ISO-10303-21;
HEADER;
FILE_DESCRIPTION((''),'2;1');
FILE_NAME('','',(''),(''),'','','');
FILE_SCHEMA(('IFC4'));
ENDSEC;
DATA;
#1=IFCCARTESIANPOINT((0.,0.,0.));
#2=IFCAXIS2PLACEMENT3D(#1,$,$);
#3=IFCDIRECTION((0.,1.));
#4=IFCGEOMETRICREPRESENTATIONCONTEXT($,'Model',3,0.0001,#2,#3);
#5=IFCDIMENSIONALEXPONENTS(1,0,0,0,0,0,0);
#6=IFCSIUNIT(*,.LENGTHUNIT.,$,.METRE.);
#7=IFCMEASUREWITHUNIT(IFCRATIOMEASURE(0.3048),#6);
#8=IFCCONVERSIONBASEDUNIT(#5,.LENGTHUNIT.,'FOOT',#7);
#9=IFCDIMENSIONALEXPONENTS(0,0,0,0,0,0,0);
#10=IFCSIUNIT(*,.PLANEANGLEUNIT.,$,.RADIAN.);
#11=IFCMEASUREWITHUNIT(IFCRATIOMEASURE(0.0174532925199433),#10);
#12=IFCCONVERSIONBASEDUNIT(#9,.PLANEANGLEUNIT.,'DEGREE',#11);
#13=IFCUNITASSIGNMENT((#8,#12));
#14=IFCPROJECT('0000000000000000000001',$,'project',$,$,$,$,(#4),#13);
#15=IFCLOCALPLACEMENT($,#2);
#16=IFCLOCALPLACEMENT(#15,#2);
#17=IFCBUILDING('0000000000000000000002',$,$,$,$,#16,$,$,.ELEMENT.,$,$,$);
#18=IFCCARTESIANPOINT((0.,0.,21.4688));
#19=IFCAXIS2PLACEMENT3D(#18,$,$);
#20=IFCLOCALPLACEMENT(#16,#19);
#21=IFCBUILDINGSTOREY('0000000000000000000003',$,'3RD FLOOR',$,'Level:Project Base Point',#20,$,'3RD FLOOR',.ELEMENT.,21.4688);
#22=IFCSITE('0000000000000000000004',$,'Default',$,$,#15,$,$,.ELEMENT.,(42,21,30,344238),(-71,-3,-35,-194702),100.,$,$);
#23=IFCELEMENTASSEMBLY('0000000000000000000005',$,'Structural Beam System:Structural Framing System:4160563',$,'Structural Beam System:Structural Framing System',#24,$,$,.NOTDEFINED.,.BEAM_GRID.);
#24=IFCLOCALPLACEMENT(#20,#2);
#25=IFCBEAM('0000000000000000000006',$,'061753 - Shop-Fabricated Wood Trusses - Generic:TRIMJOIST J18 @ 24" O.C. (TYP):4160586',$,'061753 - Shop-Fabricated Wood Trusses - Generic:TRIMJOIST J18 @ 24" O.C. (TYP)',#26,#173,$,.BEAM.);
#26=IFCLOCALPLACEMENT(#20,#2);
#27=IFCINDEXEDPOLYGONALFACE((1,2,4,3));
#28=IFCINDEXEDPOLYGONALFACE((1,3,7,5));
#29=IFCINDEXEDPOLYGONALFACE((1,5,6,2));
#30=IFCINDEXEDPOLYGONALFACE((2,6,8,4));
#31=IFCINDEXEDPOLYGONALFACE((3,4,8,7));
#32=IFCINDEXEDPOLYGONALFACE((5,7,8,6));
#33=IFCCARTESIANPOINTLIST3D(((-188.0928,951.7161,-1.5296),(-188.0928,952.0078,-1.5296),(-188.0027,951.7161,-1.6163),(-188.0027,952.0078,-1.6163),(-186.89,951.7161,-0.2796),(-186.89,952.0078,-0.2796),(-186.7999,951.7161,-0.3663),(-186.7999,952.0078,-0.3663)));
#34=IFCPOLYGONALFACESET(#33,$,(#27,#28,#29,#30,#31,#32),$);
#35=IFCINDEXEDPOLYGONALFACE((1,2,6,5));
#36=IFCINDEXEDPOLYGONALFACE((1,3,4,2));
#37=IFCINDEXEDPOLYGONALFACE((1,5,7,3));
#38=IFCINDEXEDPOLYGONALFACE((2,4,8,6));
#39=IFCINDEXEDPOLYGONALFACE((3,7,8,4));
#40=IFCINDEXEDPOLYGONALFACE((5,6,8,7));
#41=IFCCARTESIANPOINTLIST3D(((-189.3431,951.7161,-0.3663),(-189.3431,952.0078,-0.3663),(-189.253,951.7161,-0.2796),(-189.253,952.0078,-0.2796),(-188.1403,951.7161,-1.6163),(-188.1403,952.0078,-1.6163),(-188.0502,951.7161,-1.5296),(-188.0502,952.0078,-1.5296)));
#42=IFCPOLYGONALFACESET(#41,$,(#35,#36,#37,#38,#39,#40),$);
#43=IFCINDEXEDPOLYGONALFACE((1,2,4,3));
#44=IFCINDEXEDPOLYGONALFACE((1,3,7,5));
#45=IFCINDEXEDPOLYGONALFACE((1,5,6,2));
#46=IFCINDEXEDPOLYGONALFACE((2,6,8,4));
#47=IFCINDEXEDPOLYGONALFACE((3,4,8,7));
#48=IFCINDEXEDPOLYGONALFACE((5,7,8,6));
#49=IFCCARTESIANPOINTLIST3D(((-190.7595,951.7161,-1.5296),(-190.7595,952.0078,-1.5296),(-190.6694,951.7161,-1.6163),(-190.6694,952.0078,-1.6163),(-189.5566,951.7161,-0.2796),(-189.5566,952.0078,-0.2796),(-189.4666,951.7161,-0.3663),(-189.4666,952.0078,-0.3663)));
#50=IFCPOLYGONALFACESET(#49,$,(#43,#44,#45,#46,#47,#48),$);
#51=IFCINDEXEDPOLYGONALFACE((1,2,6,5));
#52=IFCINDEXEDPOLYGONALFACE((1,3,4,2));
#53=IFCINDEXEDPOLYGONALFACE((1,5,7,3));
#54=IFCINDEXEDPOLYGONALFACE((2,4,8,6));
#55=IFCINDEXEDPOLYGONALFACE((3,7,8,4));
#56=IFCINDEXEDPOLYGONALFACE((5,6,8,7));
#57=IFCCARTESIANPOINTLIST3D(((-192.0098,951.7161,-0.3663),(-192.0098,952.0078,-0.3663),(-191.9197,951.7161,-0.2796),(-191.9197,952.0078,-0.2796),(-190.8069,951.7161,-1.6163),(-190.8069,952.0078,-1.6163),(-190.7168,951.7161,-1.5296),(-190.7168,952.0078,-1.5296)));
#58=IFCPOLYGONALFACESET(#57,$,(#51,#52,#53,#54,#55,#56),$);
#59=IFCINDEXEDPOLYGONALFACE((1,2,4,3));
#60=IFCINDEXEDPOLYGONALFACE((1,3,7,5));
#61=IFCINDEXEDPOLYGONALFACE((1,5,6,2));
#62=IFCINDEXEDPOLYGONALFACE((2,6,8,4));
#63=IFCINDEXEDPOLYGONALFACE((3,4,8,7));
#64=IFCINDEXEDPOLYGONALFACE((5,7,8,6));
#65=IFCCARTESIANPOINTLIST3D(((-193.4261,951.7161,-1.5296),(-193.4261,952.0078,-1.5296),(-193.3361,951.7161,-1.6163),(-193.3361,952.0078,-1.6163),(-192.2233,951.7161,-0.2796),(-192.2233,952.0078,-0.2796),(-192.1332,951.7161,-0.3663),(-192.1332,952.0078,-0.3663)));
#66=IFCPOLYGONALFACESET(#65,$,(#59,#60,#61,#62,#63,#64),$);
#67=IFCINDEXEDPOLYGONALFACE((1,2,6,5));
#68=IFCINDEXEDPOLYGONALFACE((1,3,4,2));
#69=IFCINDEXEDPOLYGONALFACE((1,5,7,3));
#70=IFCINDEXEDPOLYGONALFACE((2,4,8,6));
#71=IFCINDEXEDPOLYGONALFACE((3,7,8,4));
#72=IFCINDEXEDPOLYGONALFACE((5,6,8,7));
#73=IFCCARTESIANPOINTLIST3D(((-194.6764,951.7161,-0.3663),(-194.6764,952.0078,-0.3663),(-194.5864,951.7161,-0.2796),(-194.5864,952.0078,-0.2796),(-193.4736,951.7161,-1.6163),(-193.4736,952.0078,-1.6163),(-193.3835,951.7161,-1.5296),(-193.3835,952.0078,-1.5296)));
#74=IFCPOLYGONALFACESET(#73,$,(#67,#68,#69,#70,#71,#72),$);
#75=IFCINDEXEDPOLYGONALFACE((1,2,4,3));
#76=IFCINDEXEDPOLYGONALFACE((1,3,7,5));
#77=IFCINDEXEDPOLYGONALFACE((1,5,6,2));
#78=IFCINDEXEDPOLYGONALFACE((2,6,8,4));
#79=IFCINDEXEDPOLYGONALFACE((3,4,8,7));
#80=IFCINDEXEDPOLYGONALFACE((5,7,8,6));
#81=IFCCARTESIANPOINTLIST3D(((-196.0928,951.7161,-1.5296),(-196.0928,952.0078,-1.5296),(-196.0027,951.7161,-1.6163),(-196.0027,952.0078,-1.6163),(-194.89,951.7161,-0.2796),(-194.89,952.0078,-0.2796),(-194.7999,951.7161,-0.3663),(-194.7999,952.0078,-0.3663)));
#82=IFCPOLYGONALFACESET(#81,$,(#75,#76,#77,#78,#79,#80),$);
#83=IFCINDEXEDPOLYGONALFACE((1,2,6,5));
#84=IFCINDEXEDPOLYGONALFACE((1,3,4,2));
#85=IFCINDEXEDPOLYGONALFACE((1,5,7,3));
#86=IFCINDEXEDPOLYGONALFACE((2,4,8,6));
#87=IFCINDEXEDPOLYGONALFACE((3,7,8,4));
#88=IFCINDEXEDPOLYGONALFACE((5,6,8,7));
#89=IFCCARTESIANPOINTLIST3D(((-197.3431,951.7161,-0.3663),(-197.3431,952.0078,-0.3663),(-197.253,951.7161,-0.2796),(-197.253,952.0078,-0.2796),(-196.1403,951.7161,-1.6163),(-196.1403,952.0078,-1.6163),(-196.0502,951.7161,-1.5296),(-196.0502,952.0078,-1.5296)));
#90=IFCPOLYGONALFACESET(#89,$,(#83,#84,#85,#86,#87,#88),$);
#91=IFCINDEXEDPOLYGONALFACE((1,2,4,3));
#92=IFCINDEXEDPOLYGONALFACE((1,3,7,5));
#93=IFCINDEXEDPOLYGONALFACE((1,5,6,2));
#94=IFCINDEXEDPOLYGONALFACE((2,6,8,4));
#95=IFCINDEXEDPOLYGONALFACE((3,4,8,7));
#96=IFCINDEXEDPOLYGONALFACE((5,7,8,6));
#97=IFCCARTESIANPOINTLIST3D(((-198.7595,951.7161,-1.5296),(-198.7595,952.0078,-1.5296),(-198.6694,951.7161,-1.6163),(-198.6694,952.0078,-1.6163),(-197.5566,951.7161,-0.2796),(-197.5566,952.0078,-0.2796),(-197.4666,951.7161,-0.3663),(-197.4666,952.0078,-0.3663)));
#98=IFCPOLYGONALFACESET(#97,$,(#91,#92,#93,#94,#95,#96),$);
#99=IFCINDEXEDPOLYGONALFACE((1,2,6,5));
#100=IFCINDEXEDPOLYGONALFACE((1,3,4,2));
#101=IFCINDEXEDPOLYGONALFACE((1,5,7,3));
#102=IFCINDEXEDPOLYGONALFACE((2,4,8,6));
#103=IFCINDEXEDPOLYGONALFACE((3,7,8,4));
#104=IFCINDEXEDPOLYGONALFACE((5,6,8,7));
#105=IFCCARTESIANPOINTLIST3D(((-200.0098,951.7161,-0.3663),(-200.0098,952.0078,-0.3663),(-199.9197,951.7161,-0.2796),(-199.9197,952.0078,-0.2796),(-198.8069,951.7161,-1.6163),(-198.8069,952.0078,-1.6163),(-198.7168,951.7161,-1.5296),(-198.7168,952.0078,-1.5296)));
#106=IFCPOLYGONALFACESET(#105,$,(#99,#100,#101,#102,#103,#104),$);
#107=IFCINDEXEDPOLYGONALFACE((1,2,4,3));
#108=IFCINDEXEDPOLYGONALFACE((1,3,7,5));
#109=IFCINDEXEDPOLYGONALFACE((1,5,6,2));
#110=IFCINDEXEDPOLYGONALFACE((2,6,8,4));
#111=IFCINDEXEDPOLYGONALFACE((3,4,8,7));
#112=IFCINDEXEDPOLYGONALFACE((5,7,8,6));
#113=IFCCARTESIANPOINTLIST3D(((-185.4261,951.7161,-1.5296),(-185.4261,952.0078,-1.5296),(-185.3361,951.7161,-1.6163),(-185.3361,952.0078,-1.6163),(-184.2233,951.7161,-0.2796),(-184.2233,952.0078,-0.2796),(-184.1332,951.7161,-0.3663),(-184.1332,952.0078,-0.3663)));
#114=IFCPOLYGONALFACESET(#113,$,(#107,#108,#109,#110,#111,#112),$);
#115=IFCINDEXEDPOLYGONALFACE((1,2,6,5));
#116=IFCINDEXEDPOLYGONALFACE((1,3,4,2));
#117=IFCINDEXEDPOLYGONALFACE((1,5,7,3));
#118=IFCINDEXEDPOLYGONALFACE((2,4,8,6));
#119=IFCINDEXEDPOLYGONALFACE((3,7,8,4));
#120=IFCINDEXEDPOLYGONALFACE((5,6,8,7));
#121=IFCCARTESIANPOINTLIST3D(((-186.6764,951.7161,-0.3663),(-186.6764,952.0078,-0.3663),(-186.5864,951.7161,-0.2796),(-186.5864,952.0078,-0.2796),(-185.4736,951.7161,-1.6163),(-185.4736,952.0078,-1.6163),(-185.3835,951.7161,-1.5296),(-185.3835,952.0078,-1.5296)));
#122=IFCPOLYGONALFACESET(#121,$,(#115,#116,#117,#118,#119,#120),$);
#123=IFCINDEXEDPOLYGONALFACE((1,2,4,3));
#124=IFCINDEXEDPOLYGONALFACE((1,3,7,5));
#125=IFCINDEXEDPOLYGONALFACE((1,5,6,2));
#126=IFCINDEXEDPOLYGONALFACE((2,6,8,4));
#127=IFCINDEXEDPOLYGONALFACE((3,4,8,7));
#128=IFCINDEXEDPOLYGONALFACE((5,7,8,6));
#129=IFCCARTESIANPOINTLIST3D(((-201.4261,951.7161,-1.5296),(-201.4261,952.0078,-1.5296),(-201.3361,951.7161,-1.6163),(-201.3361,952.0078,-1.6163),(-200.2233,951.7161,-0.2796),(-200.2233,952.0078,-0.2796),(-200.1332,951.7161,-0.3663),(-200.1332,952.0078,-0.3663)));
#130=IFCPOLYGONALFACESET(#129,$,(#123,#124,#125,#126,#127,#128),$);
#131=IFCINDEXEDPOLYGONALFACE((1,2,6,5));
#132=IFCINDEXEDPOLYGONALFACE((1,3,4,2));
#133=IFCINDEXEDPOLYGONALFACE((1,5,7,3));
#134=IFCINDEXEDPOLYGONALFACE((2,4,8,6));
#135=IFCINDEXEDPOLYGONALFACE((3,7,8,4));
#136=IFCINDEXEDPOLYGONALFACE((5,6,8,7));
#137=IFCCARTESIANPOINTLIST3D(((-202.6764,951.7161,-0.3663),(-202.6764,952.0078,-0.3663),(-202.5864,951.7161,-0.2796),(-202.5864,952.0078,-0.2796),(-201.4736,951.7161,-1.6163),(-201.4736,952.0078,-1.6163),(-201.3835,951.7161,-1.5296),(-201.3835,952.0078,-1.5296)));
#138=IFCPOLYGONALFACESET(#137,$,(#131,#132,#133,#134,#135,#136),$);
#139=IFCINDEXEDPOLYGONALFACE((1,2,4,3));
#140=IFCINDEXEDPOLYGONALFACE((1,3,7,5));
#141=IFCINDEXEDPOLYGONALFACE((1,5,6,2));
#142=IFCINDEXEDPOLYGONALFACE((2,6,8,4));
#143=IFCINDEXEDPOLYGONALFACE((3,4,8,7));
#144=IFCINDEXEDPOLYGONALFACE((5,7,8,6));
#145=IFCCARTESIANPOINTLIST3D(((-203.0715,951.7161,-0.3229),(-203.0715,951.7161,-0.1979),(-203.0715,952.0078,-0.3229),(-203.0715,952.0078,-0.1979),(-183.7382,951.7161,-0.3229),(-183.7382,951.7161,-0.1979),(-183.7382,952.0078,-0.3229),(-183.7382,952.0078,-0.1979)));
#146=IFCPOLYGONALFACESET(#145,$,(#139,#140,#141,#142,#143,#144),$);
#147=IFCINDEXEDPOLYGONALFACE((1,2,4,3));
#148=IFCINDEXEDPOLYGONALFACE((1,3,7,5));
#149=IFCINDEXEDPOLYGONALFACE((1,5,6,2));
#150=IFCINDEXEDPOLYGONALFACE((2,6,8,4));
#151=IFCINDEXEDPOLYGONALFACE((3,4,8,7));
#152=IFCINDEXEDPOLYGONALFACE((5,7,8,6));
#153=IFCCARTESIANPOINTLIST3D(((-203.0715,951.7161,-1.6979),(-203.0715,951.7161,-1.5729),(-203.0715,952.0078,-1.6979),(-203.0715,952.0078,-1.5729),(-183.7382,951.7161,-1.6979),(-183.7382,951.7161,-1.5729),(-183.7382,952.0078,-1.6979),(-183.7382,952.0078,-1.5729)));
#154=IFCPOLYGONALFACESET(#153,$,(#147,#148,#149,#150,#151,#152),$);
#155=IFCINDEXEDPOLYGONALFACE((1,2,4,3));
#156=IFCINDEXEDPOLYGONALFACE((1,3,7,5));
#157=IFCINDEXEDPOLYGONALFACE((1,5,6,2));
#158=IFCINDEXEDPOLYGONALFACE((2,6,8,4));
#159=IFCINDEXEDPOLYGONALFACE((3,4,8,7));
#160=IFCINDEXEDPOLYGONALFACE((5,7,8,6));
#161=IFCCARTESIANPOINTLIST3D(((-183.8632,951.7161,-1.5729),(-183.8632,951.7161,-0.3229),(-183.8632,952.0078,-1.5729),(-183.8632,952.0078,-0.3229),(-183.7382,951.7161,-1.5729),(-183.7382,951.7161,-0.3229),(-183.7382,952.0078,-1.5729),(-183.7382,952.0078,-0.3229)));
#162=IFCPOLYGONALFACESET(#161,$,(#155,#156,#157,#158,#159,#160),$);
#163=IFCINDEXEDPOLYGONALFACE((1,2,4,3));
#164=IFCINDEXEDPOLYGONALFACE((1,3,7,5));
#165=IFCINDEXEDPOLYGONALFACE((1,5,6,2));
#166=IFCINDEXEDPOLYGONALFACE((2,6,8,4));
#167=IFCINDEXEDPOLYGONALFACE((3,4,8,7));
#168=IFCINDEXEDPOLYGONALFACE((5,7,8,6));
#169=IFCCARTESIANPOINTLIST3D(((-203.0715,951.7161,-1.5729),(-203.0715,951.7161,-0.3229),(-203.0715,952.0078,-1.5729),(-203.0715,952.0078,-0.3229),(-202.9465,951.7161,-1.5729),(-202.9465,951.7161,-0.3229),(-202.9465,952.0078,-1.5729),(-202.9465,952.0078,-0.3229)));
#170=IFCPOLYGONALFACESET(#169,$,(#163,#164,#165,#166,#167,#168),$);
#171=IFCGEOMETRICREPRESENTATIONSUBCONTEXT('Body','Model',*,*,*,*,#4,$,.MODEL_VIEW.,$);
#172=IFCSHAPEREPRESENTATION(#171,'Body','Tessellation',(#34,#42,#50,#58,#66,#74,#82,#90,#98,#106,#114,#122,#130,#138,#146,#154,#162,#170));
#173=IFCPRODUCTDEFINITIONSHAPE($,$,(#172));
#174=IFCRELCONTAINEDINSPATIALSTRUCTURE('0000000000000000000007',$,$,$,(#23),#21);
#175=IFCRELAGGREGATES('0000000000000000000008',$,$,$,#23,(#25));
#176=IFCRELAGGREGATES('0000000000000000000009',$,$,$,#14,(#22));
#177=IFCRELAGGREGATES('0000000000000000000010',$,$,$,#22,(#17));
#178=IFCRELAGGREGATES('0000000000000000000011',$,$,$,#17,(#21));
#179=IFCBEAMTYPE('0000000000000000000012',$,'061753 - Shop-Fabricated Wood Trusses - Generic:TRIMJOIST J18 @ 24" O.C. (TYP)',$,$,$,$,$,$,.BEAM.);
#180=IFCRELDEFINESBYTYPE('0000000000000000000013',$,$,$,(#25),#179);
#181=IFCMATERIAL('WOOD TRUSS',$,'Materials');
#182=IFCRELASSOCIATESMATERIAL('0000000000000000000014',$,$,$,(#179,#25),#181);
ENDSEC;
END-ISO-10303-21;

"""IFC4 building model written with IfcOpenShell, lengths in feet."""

from ifc_helpers import new_model, entity, si_unit, converted_unit, direction, frame, frame_2d, origin, origin_2d_with_axis, place, context, subcontext, project, spatial, rectangle, extrude, source, transform, mapped, material, material_profile, profile_set, profile_usage, type_object, type_shapes, element, aggregate, save


model = new_model("IFC4")

# Units and contexts
model_context = context("Model", 3, precision=0.0001, world=origin(), true_north=direction((0.0, 1.0)))
body_context = subcontext(model_context, "Body", "Model", "MODEL_VIEW")
ifc_project = project(units=[converted_unit("LENGTHUNIT", "FOOT", entity("IfcRatioMeasure", 0.3048), si_unit("LENGTHUNIT", "METRE"), dimensions=[1, 0, 0, 0, 0, 0, 0]), converted_unit("PLANEANGLEUNIT", "DEGREE", entity("IfcRatioMeasure", 0.0174532925199433), si_unit("PLANEANGLEUNIT", "RADIAN"), dimensions=[0, 0, 0, 0, 0, 0, 0])], contexts=[model_context])

# Site, building, storey
site_placement = place(None, origin())
site = spatial("IfcSite", under=ifc_project, at=site_placement, Name="Default", CompositionType="ELEMENT", RefLatitude=(42, 21, 30, 344238), RefLongitude=(-71, -3, -35, -194702), RefElevation=100.0)
building_placement = place(site_placement, origin())
building = spatial("IfcBuilding", under=site, at=building_placement, CompositionType="ELEMENT")
storey_placement = place(building_placement, frame((0.0, 0.0, 21.4688)))
storey = spatial("IfcBuildingStorey", under=building, at=storey_placement, Name="3RD FLOOR", ObjectType="Level:Project Base Point", LongName="3RD FLOOR", CompositionType="ELEMENT", Elevation=21.4688)

# Shared definitions
ifc_material_1 = material(Name="WOOD TRUSS", Category="Materials")
ifc_material_profile_1 = material_profile(ifc_material_1, rectangle(XDim=1.7347, YDim=0.125, at=frame_2d((0.0, 0.0), x_axis=(1.0, 0.0))), Name="TRIMJOIST J18 @ 24\" O.C. (TYP)")
ifc_material_profile_2 = material_profile(ifc_material_1, rectangle(XDim=1.7347, YDim=0.125, at=frame_2d((0.0, 0.0), x_axis=(1.0, 0.0))), Name="TRIMJOIST J18 @ 24\" O.C. (TYP)")
ifc_material_profile_3 = material_profile(ifc_material_1, rectangle(XDim=1.7347, YDim=0.125, at=frame_2d((0.0, 0.0), x_axis=(1.0, 0.0))), Name="TRIMJOIST J18 @ 24\" O.C. (TYP)")
ifc_material_profile_4 = material_profile(ifc_material_1, rectangle(XDim=1.7347, YDim=0.125, at=frame_2d((0.0, 0.0), x_axis=(1.0, 0.0))), Name="TRIMJOIST J18 @ 24\" O.C. (TYP)")
ifc_material_profile_5 = material_profile(ifc_material_1, rectangle(XDim=1.7347, YDim=0.125, at=frame_2d((0.0, 0.0), x_axis=(1.0, 0.0))), Name="TRIMJOIST J18 @ 24\" O.C. (TYP)")
ifc_material_profile_6 = material_profile(ifc_material_1, rectangle(XDim=1.7347, YDim=0.125, at=frame_2d((0.0, 0.0), x_axis=(1.0, 0.0))), Name="TRIMJOIST J18 @ 24\" O.C. (TYP)")
ifc_material_profile_7 = material_profile(ifc_material_1, rectangle(XDim=1.7347, YDim=0.125, at=frame_2d((0.0, 0.0), x_axis=(1.0, 0.0))), Name="TRIMJOIST J18 @ 24\" O.C. (TYP)")
ifc_material_profile_8 = material_profile(ifc_material_1, rectangle(XDim=1.7347, YDim=0.125, at=frame_2d((0.0, 0.0), x_axis=(1.0, 0.0))), Name="TRIMJOIST J18 @ 24\" O.C. (TYP)")
ifc_material_profile_9 = material_profile(ifc_material_1, rectangle(XDim=1.7347, YDim=0.125, at=frame_2d((0.0, 0.0), x_axis=(1.0, 0.0))), Name="TRIMJOIST J18 @ 24\" O.C. (TYP)")
ifc_material_profile_10 = material_profile(ifc_material_1, rectangle(XDim=1.7347, YDim=0.125, at=origin_2d_with_axis()), Name="TRIMJOIST J18 @ 24\" O.C. (TYP)")
ifc_material_profile_11 = material_profile(ifc_material_1, rectangle(XDim=0.125, YDim=0.2917, at=origin_2d_with_axis()), Name="TRIMJOIST J18 @ 24\" O.C. (TYP)")
ifc_material_profile_12 = material_profile(ifc_material_1, rectangle(XDim=0.125, YDim=0.2917, at=origin_2d_with_axis()), Name="TRIMJOIST J18 @ 24\" O.C. (TYP)")
ifc_material_profile_13 = material_profile(ifc_material_1, rectangle(XDim=1.25, YDim=0.2917, at=origin_2d_with_axis()), Name="TRIMJOIST J18 @ 24\" O.C. (TYP)")
ifc_material_profile_14 = material_profile(ifc_material_1, rectangle(XDim=1.25, YDim=0.2917, at=origin_2d_with_axis()), Name="TRIMJOIST J18 @ 24\" O.C. (TYP)")
ifc_profile_set_1 = profile_set([ifc_material_profile_1, ifc_material_profile_2, ifc_material_profile_3, ifc_material_profile_4, ifc_material_profile_5, ifc_material_profile_6, ifc_material_profile_7, ifc_material_profile_8, ifc_material_profile_9, ifc_material_profile_10, ifc_material_profile_11, ifc_material_profile_12, ifc_material_profile_13, ifc_material_profile_14], Name="TRIMJOIST J18 @ 24\" O.C. (TYP)")

# Element assembly, beam
assembly_1_placement = place(storey_placement, origin())
assembly_1 = element("IfcElementAssembly", 1, at=assembly_1_placement, inside=storey, Name="Structural Beam System:Structural Framing System:4160563", ObjectType="Structural Beam System:Structural Framing System", AssemblyPlace="NOTDEFINED", PredefinedType="BEAM_GRID")
beam_type_1 = type_object("IfcBeamType", Name="061753 - Shop-Fabricated Wood Trusses - Generic:TRIMJOIST J18 @ 24\" O.C. (TYP)", PredefinedType="BEAM", material=ifc_profile_set_1)
shared_shape_1 = source(origin(), body_context, "Body", "SweptSolid", [
    extrude(rectangle(XDim=1.7347, YDim=0.125, at=frame_2d((0.0, 0.0), x_axis=(1.0, 0.0))), frame((5.9585, -0.1458, 0.0), z_axis=(0.0, 1.0, 0.0), x_axis=(0.693383, 0.0, 0.720569)), (0.0, 0.0, 1.0), 0.2917),
    extrude(rectangle(XDim=1.7347, YDim=0.125, at=origin_2d_with_axis()), frame((4.7082, -0.1458, 0.0), z_axis=(0.0, 1.0, 0.0), x_axis=(0.693383, 0.0, -0.720569)), (0.0, 0.0, 1.0), 0.2917),
    extrude(rectangle(XDim=1.7347, YDim=0.125, at=frame_2d((0.0, 0.0), x_axis=(1.0, 0.0))), frame((3.2918, -0.1458, 0.0), z_axis=(0.0, 1.0, 0.0), x_axis=(0.693383, 0.0, 0.720569)), (0.0, 0.0, 1.0), 0.2917),
    extrude(rectangle(XDim=1.7347, YDim=0.125, at=frame_2d((0.0, 0.0), x_axis=(1.0, 0.0))), frame((2.0415, -0.1458, 0.0), z_axis=(0.0, 1.0, 0.0), x_axis=(0.693383, 0.0, -0.720569)), (0.0, 0.0, 1.0), 0.2917),
    extrude(rectangle(XDim=1.7347, YDim=0.125, at=frame_2d((0.0, 0.0), x_axis=(1.0, 0.0))), frame((0.6251, -0.1458, 0.0), z_axis=(0.0, 1.0, 0.0), x_axis=(0.693383, 0.0, 0.720569)), (0.0, 0.0, 1.0), 0.2917),
    extrude(rectangle(XDim=1.7347, YDim=0.125, at=frame_2d((0.0, 0.0), x_axis=(1.0, 0.0))), frame((-0.6251, -0.1458, 0.0), z_axis=(0.0, 1.0, 0.0), x_axis=(0.693383, 0.0, -0.720569)), (0.0, 0.0, 1.0), 0.2917),
    extrude(rectangle(XDim=1.7347, YDim=0.125, at=frame_2d((0.0, 0.0), x_axis=(1.0, 0.0))), frame((-2.0415, -0.1458, 0.0), z_axis=(0.0, 1.0, 0.0), x_axis=(0.693383, 0.0, 0.720569)), (0.0, 0.0, 1.0), 0.2917),
    extrude(rectangle(XDim=1.7347, YDim=0.125, at=origin_2d_with_axis()), frame((-3.2918, -0.1458, 0.0), z_axis=(0.0, 1.0, 0.0), x_axis=(0.693383, 0.0, -0.720569)), (0.0, 0.0, 1.0), 0.2917),
    extrude(rectangle(XDim=1.7347, YDim=0.125, at=frame_2d((0.0, 0.0), x_axis=(1.0, 0.0))), frame((-4.7082, -0.1458, 0.0), z_axis=(0.0, 1.0, 0.0), x_axis=(0.693383, 0.0, 0.720569)), (0.0, 0.0, 1.0), 0.2917),
    extrude(rectangle(XDim=1.7347, YDim=0.125, at=frame_2d((0.0, 0.0), x_axis=(1.0, 0.0))), frame((-5.9585, -0.1458, 0.0), z_axis=(0.0, 1.0, 0.0), x_axis=(0.693383, 0.0, -0.720569)), (0.0, 0.0, 1.0), 0.2917),
    extrude(rectangle(XDim=1.7347, YDim=0.125, at=frame_2d((0.0, 0.0), x_axis=(1.0, 0.0))), frame((8.6251, -0.1458, 0.0), z_axis=(0.0, 1.0, 0.0), x_axis=(0.693383, 0.0, 0.720569)), (0.0, 0.0, 1.0), 0.2917),
    extrude(rectangle(XDim=1.7347, YDim=0.125, at=origin_2d_with_axis()), frame((7.3749, -0.1458, 0.0), z_axis=(0.0, 1.0, 0.0), x_axis=(0.693383, 0.0, -0.720569)), (0.0, 0.0, 1.0), 0.2917),
    extrude(rectangle(XDim=1.7347, YDim=0.125, at=frame_2d((0.0, 0.0), x_axis=(1.0, 0.0))), frame((-7.3749, -0.1458, 0.0), z_axis=(0.0, 1.0, 0.0), x_axis=(0.693383, 0.0, 0.720569)), (0.0, 0.0, 1.0), 0.2917),
    extrude(rectangle(XDim=1.7347, YDim=0.125, at=origin_2d_with_axis()), frame((-8.6251, -0.1458, 0.0), z_axis=(0.0, 1.0, 0.0), x_axis=(0.693383, 0.0, -0.720569)), (0.0, 0.0, 1.0), 0.2917),
    extrude(rectangle(XDim=0.125, YDim=0.2917, at=origin_2d_with_axis()), frame((-9.6667, 0.0, 0.6875), z_axis=(1.0, 0.0, 0.0), x_axis=(0.0, 0.0, -1.0)), (0.0, 0.0, 1.0), 19.3333),
    extrude(rectangle(XDim=0.125, YDim=0.2917, at=origin_2d_with_axis()), frame((-9.6667, 0.0, -0.6875), z_axis=(1.0, 0.0, 0.0), x_axis=(0.0, 0.0, -1.0)), (0.0, 0.0, 1.0), 19.3333),
    extrude(rectangle(XDim=1.25, YDim=0.2917, at=origin_2d_with_axis()), frame((9.5417, 0.0, 0.0), z_axis=(1.0, 0.0, 0.0), x_axis=(0.0, 0.0, -1.0)), (0.0, 0.0, 1.0), 0.125),
    extrude(rectangle(XDim=1.25, YDim=0.2917, at=origin_2d_with_axis()), frame((-9.6667, 0.0, 0.0), z_axis=(1.0, 0.0, 0.0), x_axis=(0.0, 0.0, -1.0)), (0.0, 0.0, 1.0), 0.125),
])
type_shapes(beam_type_1, [shared_shape_1])
ifc_profile_usage_1 = profile_usage(ifc_profile_set_1, cardinal=8)
beam_1_placement = place(assembly_1_placement, frame((-193.4048, 951.8619, -0.9479)))
beam_1 = element("IfcBeam", 2, at=beam_1_placement, type_object=beam_type_1, material=ifc_profile_usage_1, Name="061753 - Shop-Fabricated Wood Trusses - Generic:TRIMJOIST J18 @ 24\" O.C. (TYP):4160586", ObjectType="061753 - Shop-Fabricated Wood Trusses - Generic:TRIMJOIST J18 @ 24\" O.C. (TYP)", PredefinedType="BEAM", context=body_context, shape_type="MappedRepresentation", body=[
    mapped(shared_shape_1, transform((0.0, 0.0, 0.0), scale=1.0)),
])

aggregate(assembly_1, [beam_1])

save(model, "model.ifc")
